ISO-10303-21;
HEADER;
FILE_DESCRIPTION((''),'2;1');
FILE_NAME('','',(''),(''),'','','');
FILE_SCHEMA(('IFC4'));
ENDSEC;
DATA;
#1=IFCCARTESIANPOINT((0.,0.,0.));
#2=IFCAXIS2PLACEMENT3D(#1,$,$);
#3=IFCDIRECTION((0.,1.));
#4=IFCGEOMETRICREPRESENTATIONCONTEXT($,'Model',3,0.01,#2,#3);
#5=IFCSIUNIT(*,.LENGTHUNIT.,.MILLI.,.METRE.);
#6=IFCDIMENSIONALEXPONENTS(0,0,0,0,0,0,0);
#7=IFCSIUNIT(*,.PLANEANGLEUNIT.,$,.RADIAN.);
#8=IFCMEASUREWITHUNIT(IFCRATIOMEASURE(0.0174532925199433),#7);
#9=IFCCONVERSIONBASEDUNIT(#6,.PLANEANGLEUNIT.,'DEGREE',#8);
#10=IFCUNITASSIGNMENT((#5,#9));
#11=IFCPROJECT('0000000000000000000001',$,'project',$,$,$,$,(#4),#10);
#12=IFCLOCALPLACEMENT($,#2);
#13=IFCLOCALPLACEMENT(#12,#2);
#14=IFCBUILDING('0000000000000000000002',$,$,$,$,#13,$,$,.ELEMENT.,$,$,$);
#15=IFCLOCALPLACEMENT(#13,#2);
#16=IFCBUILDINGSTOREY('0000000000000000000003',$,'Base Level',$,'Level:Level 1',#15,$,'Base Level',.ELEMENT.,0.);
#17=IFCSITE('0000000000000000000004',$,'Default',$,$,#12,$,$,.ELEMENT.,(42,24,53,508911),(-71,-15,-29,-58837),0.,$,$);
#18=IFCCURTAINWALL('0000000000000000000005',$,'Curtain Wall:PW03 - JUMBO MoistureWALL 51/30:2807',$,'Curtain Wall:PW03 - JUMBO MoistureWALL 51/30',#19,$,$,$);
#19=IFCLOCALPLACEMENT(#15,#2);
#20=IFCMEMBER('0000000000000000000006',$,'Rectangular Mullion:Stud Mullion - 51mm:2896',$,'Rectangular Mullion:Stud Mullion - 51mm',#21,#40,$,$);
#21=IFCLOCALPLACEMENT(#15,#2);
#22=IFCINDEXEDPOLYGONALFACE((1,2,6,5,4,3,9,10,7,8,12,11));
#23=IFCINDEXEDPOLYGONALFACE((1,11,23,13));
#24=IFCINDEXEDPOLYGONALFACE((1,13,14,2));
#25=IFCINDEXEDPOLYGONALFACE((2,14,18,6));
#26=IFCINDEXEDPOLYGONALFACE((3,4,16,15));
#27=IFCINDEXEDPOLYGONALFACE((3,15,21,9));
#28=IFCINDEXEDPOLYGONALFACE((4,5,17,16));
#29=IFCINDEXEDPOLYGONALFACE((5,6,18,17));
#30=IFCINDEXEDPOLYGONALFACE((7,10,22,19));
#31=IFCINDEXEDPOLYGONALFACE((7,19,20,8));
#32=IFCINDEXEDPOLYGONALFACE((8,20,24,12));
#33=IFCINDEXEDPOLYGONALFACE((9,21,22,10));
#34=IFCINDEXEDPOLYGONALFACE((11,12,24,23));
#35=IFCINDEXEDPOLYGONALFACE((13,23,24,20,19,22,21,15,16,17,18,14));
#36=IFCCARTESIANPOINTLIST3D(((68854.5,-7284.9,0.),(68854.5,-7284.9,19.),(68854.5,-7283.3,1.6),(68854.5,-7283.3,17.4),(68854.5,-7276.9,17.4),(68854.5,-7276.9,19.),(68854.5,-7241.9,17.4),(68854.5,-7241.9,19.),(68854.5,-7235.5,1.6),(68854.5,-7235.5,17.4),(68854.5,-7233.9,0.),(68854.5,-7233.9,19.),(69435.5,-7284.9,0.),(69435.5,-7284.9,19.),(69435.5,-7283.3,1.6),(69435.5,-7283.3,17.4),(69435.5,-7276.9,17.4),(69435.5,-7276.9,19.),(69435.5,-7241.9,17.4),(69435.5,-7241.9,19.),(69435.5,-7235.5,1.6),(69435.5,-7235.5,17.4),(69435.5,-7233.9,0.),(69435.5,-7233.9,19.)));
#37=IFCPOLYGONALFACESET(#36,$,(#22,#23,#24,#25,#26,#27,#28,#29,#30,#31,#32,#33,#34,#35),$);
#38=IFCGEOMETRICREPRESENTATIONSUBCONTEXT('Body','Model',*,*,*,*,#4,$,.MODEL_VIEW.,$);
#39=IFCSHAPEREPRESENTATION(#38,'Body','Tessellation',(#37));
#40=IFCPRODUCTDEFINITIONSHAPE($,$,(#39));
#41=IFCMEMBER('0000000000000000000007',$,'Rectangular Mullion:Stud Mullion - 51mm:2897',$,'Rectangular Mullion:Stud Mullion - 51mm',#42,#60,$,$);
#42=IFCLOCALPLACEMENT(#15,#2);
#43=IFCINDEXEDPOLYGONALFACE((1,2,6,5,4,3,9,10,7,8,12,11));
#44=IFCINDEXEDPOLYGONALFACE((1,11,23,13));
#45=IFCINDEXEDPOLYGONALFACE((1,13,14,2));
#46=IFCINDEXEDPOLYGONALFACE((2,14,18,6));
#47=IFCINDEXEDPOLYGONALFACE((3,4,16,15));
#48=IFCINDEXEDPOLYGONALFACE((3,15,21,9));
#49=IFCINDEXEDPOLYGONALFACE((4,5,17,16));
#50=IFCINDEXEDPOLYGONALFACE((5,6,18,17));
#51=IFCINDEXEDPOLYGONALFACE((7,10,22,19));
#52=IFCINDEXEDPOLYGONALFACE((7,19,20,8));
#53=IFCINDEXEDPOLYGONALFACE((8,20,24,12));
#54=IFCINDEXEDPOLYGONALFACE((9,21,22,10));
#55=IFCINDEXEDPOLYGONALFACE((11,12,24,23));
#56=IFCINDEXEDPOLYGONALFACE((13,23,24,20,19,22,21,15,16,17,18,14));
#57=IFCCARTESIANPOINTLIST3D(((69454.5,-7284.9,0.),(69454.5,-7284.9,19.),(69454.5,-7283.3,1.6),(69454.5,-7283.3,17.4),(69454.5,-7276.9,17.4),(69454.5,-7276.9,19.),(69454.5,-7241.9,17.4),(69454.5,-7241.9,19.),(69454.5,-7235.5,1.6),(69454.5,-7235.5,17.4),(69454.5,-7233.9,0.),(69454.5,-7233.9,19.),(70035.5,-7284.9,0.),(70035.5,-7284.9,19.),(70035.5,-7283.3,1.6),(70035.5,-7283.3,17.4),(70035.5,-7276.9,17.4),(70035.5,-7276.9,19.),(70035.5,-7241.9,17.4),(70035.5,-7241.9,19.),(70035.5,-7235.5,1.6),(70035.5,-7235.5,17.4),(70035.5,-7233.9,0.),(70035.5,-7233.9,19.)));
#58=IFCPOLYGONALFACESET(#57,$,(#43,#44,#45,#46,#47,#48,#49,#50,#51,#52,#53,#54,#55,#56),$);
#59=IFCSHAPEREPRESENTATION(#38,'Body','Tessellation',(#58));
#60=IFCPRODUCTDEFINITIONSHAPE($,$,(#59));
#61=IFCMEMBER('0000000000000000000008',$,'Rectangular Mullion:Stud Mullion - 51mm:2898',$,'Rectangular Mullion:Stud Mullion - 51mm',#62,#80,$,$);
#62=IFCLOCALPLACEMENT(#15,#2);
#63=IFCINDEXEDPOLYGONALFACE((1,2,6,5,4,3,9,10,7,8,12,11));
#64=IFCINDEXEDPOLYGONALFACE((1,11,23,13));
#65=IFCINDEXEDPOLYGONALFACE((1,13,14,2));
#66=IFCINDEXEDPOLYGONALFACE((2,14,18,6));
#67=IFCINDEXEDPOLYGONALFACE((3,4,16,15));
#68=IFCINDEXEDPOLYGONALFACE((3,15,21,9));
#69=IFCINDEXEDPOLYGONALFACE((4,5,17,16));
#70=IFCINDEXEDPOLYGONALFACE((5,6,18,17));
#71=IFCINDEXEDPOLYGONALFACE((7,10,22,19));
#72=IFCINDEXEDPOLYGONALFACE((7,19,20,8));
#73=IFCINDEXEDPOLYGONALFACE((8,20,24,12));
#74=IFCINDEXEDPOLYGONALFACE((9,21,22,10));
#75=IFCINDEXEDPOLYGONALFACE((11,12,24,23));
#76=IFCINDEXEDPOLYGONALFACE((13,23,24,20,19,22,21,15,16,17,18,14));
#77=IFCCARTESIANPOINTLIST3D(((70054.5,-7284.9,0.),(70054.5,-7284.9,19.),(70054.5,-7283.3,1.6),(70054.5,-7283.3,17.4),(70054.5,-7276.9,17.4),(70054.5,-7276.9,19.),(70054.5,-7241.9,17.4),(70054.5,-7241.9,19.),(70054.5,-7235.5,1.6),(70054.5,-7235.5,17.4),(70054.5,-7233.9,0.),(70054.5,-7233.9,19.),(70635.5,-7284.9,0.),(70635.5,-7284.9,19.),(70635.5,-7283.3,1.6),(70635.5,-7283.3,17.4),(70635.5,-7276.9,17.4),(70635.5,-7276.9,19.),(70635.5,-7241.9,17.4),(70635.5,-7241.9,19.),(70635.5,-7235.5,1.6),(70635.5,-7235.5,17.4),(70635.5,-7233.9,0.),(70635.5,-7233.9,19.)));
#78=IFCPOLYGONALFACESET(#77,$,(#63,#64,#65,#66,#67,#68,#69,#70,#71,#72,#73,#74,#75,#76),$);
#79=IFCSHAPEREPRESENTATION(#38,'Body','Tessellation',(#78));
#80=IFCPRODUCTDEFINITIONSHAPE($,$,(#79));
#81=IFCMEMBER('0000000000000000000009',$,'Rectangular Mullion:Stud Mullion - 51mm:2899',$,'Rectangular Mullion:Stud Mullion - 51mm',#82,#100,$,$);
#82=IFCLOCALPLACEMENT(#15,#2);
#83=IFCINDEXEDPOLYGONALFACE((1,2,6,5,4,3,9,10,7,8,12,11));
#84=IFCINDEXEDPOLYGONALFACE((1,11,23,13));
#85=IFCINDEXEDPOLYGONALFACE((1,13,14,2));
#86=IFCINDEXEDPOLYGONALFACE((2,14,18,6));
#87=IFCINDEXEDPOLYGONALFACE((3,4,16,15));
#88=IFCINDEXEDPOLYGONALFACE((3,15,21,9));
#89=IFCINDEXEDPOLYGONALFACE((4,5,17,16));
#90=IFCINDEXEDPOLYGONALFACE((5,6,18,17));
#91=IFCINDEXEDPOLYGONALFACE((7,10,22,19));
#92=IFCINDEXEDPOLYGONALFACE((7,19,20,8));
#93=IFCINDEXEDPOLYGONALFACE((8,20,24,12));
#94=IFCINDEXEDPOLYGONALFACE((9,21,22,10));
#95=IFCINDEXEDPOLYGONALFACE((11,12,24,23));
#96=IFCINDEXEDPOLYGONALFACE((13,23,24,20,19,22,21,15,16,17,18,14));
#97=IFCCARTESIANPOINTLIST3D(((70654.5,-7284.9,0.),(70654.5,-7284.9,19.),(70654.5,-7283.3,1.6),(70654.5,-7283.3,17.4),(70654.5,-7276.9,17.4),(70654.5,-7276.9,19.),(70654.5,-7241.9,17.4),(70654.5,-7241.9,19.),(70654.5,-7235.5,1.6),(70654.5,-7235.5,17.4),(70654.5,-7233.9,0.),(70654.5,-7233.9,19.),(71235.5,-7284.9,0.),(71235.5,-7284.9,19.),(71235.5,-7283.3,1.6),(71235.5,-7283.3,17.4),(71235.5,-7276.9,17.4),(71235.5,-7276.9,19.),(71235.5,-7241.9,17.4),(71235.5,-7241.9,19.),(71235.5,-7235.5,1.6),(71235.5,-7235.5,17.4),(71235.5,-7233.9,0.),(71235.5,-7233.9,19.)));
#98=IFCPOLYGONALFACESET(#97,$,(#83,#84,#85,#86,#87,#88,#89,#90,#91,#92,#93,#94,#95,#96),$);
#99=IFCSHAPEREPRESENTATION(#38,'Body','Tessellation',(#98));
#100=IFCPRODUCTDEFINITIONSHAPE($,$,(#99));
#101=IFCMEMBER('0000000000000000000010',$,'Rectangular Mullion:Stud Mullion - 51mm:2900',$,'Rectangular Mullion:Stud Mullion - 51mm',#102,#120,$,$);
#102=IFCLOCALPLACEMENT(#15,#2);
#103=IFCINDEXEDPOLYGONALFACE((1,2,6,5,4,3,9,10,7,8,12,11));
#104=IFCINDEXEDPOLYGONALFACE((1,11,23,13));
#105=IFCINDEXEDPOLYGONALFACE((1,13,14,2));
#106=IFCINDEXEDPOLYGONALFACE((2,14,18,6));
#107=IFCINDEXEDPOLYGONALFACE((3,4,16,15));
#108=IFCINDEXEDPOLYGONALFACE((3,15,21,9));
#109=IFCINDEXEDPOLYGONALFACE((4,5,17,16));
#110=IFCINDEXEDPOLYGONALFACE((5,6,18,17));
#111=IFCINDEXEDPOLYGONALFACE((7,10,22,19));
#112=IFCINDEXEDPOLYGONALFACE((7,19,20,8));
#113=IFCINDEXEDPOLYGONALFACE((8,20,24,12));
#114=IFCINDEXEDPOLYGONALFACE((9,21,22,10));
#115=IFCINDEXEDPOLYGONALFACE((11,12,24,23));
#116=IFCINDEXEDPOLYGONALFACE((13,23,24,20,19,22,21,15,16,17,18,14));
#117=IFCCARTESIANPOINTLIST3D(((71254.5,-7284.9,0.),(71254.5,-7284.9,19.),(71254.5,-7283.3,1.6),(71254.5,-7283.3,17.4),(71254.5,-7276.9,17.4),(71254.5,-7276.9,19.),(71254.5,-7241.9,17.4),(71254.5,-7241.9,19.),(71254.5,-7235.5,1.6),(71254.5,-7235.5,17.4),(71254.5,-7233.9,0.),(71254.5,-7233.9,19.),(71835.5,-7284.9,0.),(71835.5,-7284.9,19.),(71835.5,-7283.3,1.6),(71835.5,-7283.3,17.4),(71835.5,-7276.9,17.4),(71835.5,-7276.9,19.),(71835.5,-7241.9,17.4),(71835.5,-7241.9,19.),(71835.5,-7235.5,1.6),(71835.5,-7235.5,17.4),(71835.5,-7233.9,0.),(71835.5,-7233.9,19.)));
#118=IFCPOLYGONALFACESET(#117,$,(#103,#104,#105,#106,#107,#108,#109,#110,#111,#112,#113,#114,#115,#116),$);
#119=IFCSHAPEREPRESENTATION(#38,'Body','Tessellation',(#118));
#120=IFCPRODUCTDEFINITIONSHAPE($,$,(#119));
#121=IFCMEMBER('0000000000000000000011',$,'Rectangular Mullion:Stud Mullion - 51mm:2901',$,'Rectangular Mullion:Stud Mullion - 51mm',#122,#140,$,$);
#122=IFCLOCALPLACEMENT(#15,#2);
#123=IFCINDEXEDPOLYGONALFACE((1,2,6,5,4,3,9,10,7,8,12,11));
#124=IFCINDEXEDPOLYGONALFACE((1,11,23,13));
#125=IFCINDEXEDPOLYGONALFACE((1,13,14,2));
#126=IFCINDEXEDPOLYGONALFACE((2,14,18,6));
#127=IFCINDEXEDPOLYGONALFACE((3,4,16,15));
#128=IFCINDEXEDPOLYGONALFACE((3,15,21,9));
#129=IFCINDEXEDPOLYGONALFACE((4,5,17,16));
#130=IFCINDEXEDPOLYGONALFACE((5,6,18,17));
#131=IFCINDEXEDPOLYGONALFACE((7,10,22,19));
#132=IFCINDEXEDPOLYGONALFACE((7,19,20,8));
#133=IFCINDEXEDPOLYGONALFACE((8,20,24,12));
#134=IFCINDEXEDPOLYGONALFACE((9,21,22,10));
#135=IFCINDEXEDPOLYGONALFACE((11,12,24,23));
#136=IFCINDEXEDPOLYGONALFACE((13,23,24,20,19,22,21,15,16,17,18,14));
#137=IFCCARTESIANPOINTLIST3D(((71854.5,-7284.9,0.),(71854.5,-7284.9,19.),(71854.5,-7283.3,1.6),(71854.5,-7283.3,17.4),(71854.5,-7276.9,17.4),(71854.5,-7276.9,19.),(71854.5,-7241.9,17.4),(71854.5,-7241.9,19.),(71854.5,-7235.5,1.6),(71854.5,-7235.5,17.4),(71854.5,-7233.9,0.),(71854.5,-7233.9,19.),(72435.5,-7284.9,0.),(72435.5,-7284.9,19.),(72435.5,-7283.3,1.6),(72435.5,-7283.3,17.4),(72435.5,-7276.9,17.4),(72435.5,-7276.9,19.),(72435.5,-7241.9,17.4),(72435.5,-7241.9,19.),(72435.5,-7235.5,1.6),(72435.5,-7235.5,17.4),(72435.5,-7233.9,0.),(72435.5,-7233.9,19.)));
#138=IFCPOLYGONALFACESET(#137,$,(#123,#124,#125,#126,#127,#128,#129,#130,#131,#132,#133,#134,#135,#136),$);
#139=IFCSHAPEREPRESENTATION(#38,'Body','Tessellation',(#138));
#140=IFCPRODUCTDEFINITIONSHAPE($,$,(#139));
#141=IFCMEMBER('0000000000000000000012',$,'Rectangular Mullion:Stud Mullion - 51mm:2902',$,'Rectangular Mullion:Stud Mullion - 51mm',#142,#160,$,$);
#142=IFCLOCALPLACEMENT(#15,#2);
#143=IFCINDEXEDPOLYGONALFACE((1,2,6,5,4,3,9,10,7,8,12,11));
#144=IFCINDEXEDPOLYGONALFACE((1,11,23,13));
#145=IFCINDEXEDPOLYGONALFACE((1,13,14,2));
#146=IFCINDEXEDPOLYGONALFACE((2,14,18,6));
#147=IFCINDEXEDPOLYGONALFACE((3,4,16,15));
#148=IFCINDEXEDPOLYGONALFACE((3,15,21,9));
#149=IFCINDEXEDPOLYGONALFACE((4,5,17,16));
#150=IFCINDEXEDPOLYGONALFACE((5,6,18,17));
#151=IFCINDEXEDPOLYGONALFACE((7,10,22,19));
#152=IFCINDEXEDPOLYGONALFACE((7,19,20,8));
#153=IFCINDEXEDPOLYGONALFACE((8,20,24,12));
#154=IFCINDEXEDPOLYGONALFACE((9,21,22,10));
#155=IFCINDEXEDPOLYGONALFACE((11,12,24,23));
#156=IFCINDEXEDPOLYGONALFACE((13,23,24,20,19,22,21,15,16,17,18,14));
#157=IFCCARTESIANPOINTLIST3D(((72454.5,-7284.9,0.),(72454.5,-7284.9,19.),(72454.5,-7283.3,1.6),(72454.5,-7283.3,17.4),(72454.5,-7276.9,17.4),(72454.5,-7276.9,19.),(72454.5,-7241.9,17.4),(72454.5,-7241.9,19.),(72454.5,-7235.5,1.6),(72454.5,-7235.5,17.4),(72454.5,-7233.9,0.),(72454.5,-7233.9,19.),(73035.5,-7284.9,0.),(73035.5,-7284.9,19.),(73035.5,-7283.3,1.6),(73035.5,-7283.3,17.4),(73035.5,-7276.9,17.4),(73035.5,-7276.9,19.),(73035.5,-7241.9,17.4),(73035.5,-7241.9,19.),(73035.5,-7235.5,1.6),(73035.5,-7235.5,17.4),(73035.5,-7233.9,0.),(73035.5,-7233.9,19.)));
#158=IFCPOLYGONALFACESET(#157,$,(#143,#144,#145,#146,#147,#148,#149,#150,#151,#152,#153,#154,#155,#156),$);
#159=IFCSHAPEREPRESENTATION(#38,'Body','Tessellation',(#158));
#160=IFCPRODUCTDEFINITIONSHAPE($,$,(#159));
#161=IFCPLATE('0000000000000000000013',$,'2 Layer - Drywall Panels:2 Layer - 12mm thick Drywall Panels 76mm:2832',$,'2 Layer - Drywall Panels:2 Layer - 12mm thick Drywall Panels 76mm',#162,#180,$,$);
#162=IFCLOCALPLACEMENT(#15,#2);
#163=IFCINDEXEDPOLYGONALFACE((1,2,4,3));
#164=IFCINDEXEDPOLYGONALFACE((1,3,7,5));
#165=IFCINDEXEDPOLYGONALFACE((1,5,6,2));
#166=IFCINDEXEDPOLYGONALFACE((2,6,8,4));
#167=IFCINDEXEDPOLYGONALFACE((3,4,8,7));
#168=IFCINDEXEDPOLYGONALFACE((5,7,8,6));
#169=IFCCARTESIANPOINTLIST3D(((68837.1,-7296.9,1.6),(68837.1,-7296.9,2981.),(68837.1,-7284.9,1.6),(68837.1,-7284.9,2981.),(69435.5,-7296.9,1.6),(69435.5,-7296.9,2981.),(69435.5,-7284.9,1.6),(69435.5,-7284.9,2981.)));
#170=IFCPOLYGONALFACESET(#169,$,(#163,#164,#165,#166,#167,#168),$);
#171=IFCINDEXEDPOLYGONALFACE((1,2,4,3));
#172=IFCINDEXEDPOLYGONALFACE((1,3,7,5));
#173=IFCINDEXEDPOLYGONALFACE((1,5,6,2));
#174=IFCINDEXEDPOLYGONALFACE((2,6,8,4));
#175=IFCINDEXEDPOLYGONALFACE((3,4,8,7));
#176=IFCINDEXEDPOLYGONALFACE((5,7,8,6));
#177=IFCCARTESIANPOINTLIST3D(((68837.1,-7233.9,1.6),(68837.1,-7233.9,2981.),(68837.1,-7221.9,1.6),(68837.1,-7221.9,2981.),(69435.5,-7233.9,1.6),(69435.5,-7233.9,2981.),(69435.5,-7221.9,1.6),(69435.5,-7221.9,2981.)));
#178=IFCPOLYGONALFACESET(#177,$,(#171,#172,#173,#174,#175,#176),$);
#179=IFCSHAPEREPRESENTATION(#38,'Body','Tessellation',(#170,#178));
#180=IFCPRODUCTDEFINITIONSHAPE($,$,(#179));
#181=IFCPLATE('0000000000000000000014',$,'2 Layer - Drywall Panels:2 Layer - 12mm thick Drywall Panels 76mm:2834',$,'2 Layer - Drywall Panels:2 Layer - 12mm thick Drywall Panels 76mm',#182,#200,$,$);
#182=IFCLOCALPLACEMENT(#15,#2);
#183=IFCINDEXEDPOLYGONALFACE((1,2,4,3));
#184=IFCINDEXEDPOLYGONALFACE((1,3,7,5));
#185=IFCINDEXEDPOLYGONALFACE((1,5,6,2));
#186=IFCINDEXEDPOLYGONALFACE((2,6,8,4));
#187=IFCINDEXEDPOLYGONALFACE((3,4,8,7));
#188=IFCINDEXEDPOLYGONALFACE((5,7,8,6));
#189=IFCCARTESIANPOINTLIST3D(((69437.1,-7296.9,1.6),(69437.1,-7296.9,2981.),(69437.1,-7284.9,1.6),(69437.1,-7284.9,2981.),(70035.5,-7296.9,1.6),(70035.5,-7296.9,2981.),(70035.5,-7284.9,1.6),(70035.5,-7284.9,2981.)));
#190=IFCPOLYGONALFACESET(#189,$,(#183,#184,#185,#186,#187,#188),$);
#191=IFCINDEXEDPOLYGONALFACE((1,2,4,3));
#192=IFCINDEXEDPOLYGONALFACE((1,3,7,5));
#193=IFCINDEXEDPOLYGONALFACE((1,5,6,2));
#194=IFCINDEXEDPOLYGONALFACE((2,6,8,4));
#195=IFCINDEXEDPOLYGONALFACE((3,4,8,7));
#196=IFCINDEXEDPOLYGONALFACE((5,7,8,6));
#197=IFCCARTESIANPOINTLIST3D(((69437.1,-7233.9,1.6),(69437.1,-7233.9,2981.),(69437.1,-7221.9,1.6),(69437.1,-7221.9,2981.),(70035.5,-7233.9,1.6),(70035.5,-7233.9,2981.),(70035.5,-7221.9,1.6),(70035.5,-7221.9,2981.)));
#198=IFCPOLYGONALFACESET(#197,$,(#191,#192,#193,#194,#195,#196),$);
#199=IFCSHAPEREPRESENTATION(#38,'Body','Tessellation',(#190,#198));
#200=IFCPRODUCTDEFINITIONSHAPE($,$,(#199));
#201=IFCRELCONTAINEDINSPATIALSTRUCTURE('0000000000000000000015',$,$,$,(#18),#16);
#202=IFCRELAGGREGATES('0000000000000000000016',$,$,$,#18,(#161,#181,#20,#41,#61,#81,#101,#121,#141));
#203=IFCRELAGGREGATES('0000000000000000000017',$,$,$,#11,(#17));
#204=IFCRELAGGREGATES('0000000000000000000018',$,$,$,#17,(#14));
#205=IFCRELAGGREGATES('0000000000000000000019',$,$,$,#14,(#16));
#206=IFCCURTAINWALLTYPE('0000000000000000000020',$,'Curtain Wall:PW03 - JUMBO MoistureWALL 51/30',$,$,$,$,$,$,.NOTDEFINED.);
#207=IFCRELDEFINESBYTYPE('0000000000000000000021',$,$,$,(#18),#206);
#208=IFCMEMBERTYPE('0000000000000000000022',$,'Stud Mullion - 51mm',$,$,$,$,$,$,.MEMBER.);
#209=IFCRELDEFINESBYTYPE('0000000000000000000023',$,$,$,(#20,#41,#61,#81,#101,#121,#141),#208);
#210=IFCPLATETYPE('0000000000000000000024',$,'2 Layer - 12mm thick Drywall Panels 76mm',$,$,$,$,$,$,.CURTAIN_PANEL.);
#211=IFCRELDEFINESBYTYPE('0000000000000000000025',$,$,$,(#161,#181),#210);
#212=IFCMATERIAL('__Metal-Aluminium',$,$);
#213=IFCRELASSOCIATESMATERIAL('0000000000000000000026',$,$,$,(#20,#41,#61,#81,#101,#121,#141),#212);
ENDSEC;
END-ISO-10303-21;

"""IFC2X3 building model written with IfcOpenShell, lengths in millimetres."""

from ifc_helpers import new_model, entity, si_unit, converted_unit, direction, frame, frame_2d, origin, origin_2d_with_axis, place, context, subcontext, project, spatial, polyline, rectangle, outline, extrude, source, transform, mapped, material, type_object, type_shapes, element, aggregate, save


model = new_model("IFC2X3")

# Units and contexts
model_context = context("Model", 3, precision=0.01, world=origin(), true_north=direction((0.0, 1.0)))
body_context = subcontext(model_context, "Body", "Model", "MODEL_VIEW")
ifc_project = project(units=[si_unit("LENGTHUNIT", "METRE", prefix="MILLI"), converted_unit("PLANEANGLEUNIT", "DEGREE", entity("IfcRatioMeasure", 0.0174532925199433), si_unit("PLANEANGLEUNIT", "RADIAN"), dimensions=[0, 0, 0, 0, 0, 0, 0])], contexts=[model_context])

# Site, building, storey
site_placement = place(None, origin())
site = spatial("IfcSite", under=ifc_project, at=site_placement, Name="Default", CompositionType="ELEMENT", RefLatitude=(42, 24, 53, 508911), RefLongitude=(-71, -15, -29, -58837), RefElevation=0.0)
building_placement = place(site_placement, origin())
building = spatial("IfcBuilding", under=site, at=building_placement, CompositionType="ELEMENT")
storey_placement = place(building_placement, origin())
storey = spatial("IfcBuildingStorey", under=building, at=storey_placement, Name="Base Level", ObjectType="Level:Level 1", LongName="Base Level", CompositionType="ELEMENT", Elevation=0.0)

# Curtain wall, members, plates
curtain_wall_type = type_object("IfcCurtainWallType", Name="Curtain Wall:PW03 - JUMBO MoistureWALL 51/30", PredefinedType="NOTDEFINED")
curtain_wall_placement = place(building_placement, origin())
curtain_wall = element("IfcCurtainWall", 1, at=curtain_wall_placement, inside=storey, type_object=curtain_wall_type, Name="Curtain Wall:PW03 - JUMBO MoistureWALL 51/30:2807", ObjectType="Curtain Wall:PW03 - JUMBO MoistureWALL 51/30")
ifc_material = material(Name="__Metal-Aluminium")
member_type_1 = type_object("IfcMemberType", Name="Stud Mullion - 51mm", PredefinedType="MEMBER")
shared_shape_1 = source(origin(), body_context, "Body", "SweptSolid", [
    extrude(outline(polyline([(17.5, -6.6), (25.5, -6.6), (25.5, 12.4), (-25.5, 12.4), (-25.5, -6.6), (-17.5, -6.6), (-17.5, -5.0), (-23.9, -5.0), (-23.9, 10.8), (23.9, 10.8), (23.9, -5.0), (17.5, -5.0), (17.5, -6.6)])), frame((-12.4, 0.0, -581.0), z_axis=(0.0, 0.0, 1.0), x_axis=(0.0, -1.0, 0.0)), (0.0, 0.0, 1.0), 581.0),
])
type_shapes(member_type_1, [shared_shape_1])
member_1_placement = place(building_placement, frame((68854.5, -7259.4, 0.0), z_axis=(-1.0, 0.0, 0.0), x_axis=(0.0, 0.0, -1.0)))
member_1 = element("IfcMember", 2, at=member_1_placement, type_object=member_type_1, material=ifc_material, Name="Rectangular Mullion:Stud Mullion - 51mm:2896", ObjectType="Rectangular Mullion:Stud Mullion - 51mm", context=body_context, shape_type="MappedRepresentation", body=[
    mapped(shared_shape_1, transform((0.0, 0.0, 0.0), scale=1.0)),
])
member_2_placement = place(building_placement, frame((69454.5, -7259.4, 0.0), z_axis=(-1.0, 0.0, 0.0), x_axis=(0.0, 0.0, -1.0)))
member_2 = element("IfcMember", 3, at=member_2_placement, type_object=member_type_1, material=ifc_material, Name="Rectangular Mullion:Stud Mullion - 51mm:2897", ObjectType="Rectangular Mullion:Stud Mullion - 51mm", context=body_context, shape_type="MappedRepresentation", body=[
    mapped(shared_shape_1, transform((0.0, 0.0, 0.0), scale=1.0)),
])
member_3_placement = place(building_placement, frame((70054.5, -7259.4, 0.0), z_axis=(-1.0, 0.0, 0.0), x_axis=(0.0, 0.0, -1.0)))
member_3 = element("IfcMember", 4, at=member_3_placement, type_object=member_type_1, material=ifc_material, Name="Rectangular Mullion:Stud Mullion - 51mm:2898", ObjectType="Rectangular Mullion:Stud Mullion - 51mm", context=body_context, shape_type="MappedRepresentation", body=[
    mapped(shared_shape_1, transform((0.0, 0.0, 0.0), scale=1.0)),
])
member_4_placement = place(building_placement, frame((70654.5, -7259.4, 0.0), z_axis=(-1.0, 0.0, 0.0), x_axis=(0.0, 0.0, -1.0)))
member_4 = element("IfcMember", 5, at=member_4_placement, type_object=member_type_1, material=ifc_material, Name="Rectangular Mullion:Stud Mullion - 51mm:2899", ObjectType="Rectangular Mullion:Stud Mullion - 51mm", context=body_context, shape_type="MappedRepresentation", body=[
    mapped(shared_shape_1, transform((0.0, 0.0, 0.0), scale=1.0)),
])
member_5_placement = place(building_placement, frame((71254.5, -7259.4, 0.0), z_axis=(-1.0, 0.0, 0.0), x_axis=(0.0, 0.0, -1.0)))
member_5 = element("IfcMember", 6, at=member_5_placement, type_object=member_type_1, material=ifc_material, Name="Rectangular Mullion:Stud Mullion - 51mm:2900", ObjectType="Rectangular Mullion:Stud Mullion - 51mm", context=body_context, shape_type="MappedRepresentation", body=[
    mapped(shared_shape_1, transform((0.0, 0.0, 0.0), scale=1.0)),
])
member_6_placement = place(building_placement, frame((71854.5, -7259.4, 0.0), z_axis=(-1.0, 0.0, 0.0), x_axis=(0.0, 0.0, -1.0)))
member_6 = element("IfcMember", 7, at=member_6_placement, type_object=member_type_1, material=ifc_material, Name="Rectangular Mullion:Stud Mullion - 51mm:2901", ObjectType="Rectangular Mullion:Stud Mullion - 51mm", context=body_context, shape_type="MappedRepresentation", body=[
    mapped(shared_shape_1, transform((0.0, 0.0, 0.0), scale=1.0)),
])
member_7_placement = place(building_placement, frame((72454.5, -7259.4, 0.0), z_axis=(-1.0, 0.0, 0.0), x_axis=(0.0, 0.0, -1.0)))
member_7 = element("IfcMember", 8, at=member_7_placement, type_object=member_type_1, material=ifc_material, Name="Rectangular Mullion:Stud Mullion - 51mm:2902", ObjectType="Rectangular Mullion:Stud Mullion - 51mm", context=body_context, shape_type="MappedRepresentation", body=[
    mapped(shared_shape_1, transform((0.0, 0.0, 0.0), scale=1.0)),
])
plate_type = type_object("IfcPlateType", Name="2 Layer - 12mm thick Drywall Panels 76mm", PredefinedType="CURTAIN_PANEL")
shared_shape_2 = source(origin(), body_context, "Body", "SweptSolid", [
    extrude(rectangle(XDim=598.4, YDim=12.0, at=origin_2d_with_axis()), frame((0.0, -31.5, 0.0), z_axis=(0.0, 0.0, 1.0), x_axis=(-1.0, 0.0, 0.0)), (0.0, 0.0, 1.0), 2979.4),
    extrude(rectangle(XDim=12.0, YDim=598.4, at=frame_2d((0.0, 0.0), x_axis=(1.0, 0.0))), frame((0.0, 31.5, 0.0), z_axis=(0.0, 0.0, 1.0), x_axis=(0.0, 1.0, 0.0)), (0.0, 0.0, 1.0), 2979.4),
])
type_shapes(plate_type, [shared_shape_2])
plate_1_placement = place(curtain_wall_placement, frame((69136.3, -7259.4, 1.6)))
plate_1 = element("IfcPlate", 9, at=plate_1_placement, type_object=plate_type, Name="2 Layer - Drywall Panels:2 Layer - 12mm thick Drywall Panels 76mm:2832", ObjectType="2 Layer - Drywall Panels:2 Layer - 12mm thick Drywall Panels 76mm", context=body_context, shape_type="MappedRepresentation", body=[
    mapped(shared_shape_2, transform((0.0, 0.0, 0.0), scale=1.0)),
])
plate_2_placement = place(curtain_wall_placement, frame((69736.3, -7259.4, 1.6)))
plate_2 = element("IfcPlate", 10, at=plate_2_placement, type_object=plate_type, Name="2 Layer - Drywall Panels:2 Layer - 12mm thick Drywall Panels 76mm:2834", ObjectType="2 Layer - Drywall Panels:2 Layer - 12mm thick Drywall Panels 76mm", context=body_context, shape_type="MappedRepresentation", body=[
    mapped(shared_shape_2, transform((0.0, 0.0, 0.0), scale=1.0)),
])
aggregate(curtain_wall, [plate_1, plate_2, member_1, member_2, member_3, member_4, member_5, member_6, member_7])

save(model, "model.ifc")
